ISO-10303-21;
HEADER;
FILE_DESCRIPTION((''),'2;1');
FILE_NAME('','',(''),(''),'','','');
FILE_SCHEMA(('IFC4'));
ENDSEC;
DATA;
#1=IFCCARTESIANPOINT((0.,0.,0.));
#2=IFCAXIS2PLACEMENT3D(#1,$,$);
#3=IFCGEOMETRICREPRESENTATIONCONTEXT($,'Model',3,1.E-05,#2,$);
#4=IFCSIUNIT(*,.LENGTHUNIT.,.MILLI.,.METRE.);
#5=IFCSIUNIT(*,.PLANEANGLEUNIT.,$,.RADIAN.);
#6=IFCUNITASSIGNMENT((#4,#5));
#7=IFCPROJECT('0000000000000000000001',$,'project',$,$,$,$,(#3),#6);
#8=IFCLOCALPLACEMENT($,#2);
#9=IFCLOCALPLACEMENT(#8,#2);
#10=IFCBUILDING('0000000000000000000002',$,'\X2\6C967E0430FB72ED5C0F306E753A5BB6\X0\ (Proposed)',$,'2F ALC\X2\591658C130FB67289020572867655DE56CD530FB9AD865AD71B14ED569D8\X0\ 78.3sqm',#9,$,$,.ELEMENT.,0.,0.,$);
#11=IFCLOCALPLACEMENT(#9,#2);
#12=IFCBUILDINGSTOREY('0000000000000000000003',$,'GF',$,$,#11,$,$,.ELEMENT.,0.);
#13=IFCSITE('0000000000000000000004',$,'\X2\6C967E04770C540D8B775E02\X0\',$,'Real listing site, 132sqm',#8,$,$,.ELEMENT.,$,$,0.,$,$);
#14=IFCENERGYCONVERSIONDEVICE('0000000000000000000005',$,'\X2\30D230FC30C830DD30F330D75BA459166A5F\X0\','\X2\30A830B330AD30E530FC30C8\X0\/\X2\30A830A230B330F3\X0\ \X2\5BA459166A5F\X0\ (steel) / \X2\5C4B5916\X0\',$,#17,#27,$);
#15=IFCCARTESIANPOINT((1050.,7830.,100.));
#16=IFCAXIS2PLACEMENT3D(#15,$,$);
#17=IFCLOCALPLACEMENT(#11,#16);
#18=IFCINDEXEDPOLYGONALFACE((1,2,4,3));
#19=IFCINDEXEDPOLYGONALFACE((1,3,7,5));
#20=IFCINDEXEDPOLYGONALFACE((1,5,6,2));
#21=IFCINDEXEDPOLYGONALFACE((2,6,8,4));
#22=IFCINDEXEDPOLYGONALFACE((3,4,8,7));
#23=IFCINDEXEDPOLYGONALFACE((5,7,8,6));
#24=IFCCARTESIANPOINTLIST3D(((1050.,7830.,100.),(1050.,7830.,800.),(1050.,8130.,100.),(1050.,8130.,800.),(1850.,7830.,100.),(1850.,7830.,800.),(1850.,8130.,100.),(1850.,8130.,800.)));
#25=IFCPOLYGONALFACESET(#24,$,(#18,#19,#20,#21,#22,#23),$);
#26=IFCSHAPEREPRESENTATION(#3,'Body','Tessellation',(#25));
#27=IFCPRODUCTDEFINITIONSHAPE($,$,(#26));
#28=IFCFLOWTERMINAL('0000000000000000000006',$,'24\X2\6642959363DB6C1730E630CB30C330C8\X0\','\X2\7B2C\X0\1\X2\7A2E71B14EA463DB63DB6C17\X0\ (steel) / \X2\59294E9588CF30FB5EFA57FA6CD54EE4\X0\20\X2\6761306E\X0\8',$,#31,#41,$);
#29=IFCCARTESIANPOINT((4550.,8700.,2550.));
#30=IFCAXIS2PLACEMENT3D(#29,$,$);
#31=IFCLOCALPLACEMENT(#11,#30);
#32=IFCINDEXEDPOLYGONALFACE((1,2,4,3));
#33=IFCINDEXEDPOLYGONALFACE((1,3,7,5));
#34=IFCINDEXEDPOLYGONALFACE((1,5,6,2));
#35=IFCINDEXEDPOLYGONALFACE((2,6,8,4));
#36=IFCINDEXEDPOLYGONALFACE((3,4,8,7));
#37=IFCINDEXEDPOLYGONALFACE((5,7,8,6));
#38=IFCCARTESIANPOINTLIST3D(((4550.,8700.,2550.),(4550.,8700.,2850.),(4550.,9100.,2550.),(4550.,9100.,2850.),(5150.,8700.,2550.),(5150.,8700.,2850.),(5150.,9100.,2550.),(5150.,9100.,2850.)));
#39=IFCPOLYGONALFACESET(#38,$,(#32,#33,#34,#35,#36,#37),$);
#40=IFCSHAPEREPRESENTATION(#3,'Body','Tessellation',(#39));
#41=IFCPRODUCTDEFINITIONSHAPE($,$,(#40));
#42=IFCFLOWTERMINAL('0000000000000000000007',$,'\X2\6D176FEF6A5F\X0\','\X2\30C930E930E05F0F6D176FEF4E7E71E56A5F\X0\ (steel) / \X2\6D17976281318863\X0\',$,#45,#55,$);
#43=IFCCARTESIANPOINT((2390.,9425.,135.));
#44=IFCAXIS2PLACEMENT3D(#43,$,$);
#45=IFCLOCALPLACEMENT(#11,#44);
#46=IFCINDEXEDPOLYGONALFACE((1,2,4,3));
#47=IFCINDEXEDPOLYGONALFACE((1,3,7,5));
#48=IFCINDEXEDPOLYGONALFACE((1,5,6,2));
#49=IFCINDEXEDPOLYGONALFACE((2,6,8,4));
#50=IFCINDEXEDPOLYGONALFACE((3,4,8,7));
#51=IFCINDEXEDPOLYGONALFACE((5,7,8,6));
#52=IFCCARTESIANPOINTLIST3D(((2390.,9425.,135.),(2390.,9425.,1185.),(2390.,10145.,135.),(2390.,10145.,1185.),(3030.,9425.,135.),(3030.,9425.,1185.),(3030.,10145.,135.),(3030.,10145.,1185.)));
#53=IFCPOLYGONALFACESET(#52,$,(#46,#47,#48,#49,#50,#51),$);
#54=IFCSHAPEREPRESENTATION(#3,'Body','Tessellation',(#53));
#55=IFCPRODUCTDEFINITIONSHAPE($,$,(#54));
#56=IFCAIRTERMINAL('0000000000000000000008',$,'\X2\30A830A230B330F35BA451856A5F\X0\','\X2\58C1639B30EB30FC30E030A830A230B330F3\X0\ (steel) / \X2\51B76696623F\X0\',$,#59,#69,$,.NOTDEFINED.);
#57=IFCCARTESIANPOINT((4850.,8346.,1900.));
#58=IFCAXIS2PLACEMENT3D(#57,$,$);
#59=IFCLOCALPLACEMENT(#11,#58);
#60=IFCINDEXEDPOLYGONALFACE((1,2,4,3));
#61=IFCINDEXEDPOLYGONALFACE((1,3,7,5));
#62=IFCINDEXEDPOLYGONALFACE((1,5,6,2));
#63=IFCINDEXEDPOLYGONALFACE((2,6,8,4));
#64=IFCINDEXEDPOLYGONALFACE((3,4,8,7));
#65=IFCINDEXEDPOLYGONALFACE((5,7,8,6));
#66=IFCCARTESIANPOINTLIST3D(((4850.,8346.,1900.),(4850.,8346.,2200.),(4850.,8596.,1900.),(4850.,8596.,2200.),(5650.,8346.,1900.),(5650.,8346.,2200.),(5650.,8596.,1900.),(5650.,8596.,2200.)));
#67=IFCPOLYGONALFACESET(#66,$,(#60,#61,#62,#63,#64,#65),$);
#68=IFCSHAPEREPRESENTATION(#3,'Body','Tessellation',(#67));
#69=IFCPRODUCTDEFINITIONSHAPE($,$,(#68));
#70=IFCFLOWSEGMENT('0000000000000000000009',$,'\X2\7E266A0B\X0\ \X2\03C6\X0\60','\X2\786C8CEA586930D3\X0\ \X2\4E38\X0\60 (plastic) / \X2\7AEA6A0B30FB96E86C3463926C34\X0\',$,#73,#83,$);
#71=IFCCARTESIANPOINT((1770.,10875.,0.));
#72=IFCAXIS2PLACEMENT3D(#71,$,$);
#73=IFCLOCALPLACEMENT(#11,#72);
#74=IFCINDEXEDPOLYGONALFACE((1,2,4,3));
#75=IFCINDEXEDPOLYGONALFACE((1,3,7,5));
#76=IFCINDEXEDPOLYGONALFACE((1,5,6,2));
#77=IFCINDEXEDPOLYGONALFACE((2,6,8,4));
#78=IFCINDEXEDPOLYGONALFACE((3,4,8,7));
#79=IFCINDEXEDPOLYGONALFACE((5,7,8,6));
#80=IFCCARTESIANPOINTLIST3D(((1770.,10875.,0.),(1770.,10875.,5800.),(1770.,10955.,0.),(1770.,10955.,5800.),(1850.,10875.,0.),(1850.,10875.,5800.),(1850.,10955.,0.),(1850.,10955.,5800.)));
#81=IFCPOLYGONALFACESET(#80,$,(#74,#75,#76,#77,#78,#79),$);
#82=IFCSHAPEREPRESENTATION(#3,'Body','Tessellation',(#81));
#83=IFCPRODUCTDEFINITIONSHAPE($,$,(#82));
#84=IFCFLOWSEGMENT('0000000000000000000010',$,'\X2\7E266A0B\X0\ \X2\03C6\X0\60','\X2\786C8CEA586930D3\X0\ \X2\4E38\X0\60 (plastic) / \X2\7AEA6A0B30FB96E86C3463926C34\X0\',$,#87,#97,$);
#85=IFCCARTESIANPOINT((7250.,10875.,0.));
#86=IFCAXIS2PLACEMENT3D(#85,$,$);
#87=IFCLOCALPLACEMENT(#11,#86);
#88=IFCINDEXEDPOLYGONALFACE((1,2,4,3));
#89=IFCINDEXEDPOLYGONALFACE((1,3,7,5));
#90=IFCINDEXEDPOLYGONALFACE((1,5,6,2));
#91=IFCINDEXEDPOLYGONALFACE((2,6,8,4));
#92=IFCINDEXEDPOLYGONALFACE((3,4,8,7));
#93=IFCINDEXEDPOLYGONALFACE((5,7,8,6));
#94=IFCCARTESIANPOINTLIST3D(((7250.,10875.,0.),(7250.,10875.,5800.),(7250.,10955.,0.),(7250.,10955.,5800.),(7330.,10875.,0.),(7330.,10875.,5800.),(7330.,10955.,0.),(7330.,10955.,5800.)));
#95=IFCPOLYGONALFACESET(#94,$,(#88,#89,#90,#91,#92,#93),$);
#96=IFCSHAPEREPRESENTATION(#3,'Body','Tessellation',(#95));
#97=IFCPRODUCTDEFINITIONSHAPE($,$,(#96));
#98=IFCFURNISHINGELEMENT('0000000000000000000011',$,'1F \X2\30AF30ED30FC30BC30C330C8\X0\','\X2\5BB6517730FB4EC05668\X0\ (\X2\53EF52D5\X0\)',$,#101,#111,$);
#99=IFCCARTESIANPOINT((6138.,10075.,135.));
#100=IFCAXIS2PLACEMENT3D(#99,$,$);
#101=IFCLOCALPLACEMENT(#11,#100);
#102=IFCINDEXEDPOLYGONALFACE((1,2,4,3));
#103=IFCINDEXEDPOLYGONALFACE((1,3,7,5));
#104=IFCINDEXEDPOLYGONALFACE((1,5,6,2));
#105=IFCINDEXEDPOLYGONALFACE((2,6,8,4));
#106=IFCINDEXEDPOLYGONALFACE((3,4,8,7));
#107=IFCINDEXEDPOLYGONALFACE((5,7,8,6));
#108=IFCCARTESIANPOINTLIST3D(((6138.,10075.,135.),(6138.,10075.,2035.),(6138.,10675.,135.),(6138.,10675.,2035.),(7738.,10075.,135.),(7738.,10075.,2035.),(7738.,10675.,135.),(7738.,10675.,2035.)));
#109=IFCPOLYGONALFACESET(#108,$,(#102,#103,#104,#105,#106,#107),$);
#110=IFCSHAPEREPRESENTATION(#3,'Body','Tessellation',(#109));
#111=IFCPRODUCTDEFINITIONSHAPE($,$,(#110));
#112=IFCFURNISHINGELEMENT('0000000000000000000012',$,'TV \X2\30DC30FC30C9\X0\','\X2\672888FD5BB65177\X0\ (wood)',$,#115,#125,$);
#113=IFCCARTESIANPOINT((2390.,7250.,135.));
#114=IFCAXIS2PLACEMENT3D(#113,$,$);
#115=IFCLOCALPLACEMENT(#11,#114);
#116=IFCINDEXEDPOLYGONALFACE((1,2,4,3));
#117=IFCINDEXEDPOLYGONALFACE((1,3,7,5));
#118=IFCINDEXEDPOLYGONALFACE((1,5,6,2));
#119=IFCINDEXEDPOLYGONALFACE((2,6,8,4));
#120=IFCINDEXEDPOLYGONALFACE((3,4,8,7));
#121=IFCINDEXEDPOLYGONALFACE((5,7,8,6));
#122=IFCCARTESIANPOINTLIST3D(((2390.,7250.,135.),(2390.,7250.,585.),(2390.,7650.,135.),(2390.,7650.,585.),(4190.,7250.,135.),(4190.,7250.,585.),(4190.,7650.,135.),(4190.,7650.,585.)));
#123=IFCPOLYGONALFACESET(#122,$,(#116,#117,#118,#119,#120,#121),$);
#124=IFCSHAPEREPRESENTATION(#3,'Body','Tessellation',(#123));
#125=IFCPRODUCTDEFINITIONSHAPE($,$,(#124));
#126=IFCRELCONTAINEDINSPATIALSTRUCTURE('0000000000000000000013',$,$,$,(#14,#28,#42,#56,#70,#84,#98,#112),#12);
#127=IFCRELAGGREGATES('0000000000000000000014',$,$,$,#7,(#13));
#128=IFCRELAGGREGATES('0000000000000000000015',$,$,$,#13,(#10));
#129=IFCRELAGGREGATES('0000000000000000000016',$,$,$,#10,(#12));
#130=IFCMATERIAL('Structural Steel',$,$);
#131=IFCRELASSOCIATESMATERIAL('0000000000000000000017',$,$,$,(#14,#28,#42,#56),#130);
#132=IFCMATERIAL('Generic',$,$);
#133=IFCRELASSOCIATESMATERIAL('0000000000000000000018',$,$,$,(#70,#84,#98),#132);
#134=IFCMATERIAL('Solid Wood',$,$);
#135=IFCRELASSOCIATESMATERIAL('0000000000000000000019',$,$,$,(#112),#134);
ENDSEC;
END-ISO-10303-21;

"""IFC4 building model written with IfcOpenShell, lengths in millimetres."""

from ifc_helpers import new_model, si_unit, frame, frame_2d, origin, place, context, project, spatial, rectangle, extrude, material, element, save


model = new_model("IFC4")

# Units and contexts
model_context = context("Model", 3, precision=1e-05, world=origin())
ifc_project = project(units=[si_unit("LENGTHUNIT", "METRE", prefix="MILLI"), si_unit("PLANEANGLEUNIT", "RADIAN")], contexts=[model_context])

# Site, building, storey
site_placement = place(None, origin())
site = spatial("IfcSite", under=ifc_project, at=site_placement, Name="沖縄県名護市", ObjectType="Real listing site, 132sqm", CompositionType="ELEMENT", RefElevation=0.0)
building_placement = place(site_placement, origin())
building = spatial("IfcBuilding", under=site, at=building_placement, Name="沖縄・狭小の町家 (Proposed)", ObjectType="2F ALC外壁・木造在来工法・高断熱仕様 78.3sqm", CompositionType="ELEMENT", ElevationOfRefHeight=0.0, ElevationOfTerrain=0.0)
storey_placement = place(building_placement, origin())
storey = spatial("IfcBuildingStorey", under=building, at=storey_placement, Name="GF", CompositionType="ELEMENT", Elevation=0.0)

# Shared definitions
ifc_material_1 = material(Name="Solid Wood")

# Shared definitions
ifc_material_2 = material(Name="Generic")

# Shared definitions
ifc_material_3 = material(Name="Structural Steel")

# Energy conversion device
energy_conversion_device_placement = place(storey_placement, frame((1050.0, 7830.0, 100.0)))
element("IfcEnergyConversionDevice", 1, at=energy_conversion_device_placement, inside=storey, material=ifc_material_3, Name="ヒートポンプ室外機", Description="エコキュート/エアコン 室外機 (steel) / 屋外", context=model_context, shape_type="SweptSolid", body=[
    extrude(rectangle(XDim=800.0, YDim=300.0, at=frame_2d((400.0, 150.0))), frame((1050.0, 7830.0, 100.0)), (0.0, 0.0, 1.0), 700.0),
])

# Flow terminals
flow_terminal_1_placement = place(storey_placement, frame((4550.0, 8700.0, 2550.0)))
element("IfcFlowTerminal", 2, at=flow_terminal_1_placement, inside=storey, material=ifc_material_3, Name="24時間換気ユニット", Description="第1種熱交換換気 (steel) / 天井裏・建基法令20条の8", context=model_context, shape_type="SweptSolid", body=[
    extrude(rectangle(XDim=600.0, YDim=400.0, at=frame_2d((300.0, 200.0))), frame((4550.0, 8700.0, 2550.0)), (0.0, 0.0, 1.0), 300.0),
])
flow_terminal_2_placement = place(storey_placement, frame((2390.0, 9425.0, 135.0)))
element("IfcFlowTerminal", 3, at=flow_terminal_2_placement, inside=storey, material=ifc_material_3, Name="洗濯機", Description="ドラム式洗濯乾燥機 (steel) / 洗面脱衣", context=model_context, shape_type="SweptSolid", body=[
    extrude(rectangle(XDim=640.0, YDim=720.0, at=frame_2d((320.0, 360.0))), frame((2390.0, 9425.0, 135.0)), (0.0, 0.0, 1.0), 1050.0),
])

# Air terminal
air_terminal_placement = place(storey_placement, frame((4850.0, 8346.0, 1900.0)))
element("IfcAirTerminal", 4, at=air_terminal_placement, inside=storey, material=ifc_material_3, Name="エアコン室内機", Description="壁掛ルームエアコン (steel) / 冷暖房", PredefinedType="NOTDEFINED", context=model_context, shape_type="SweptSolid", body=[
    extrude(rectangle(XDim=800.0, YDim=250.0, at=frame_2d((400.0, 125.0))), frame((4850.0, 8346.0, 1900.0)), (0.0, 0.0, 1.0), 300.0),
])

# Flow segments
flow_segment_1_placement = place(storey_placement, frame((1770.0, 10875.0, 0.0)))
element("IfcFlowSegment", 5, at=flow_segment_1_placement, inside=storey, material=ifc_material_2, Name="縦樋 φ60", Description="硬質塩ビ 丸60 (plastic) / 竪樋・雨水排水", context=model_context, shape_type="SweptSolid", body=[
    extrude(rectangle(XDim=80.0, YDim=80.0, at=frame_2d((40.0, 40.0))), frame((1770.0, 10875.0, 0.0)), (0.0, 0.0, 1.0), 5800.0),
])
flow_segment_2_placement = place(storey_placement, frame((7250.0, 10875.0, 0.0)))
element("IfcFlowSegment", 6, at=flow_segment_2_placement, inside=storey, material=ifc_material_2, Name="縦樋 φ60", Description="硬質塩ビ 丸60 (plastic) / 竪樋・雨水排水", context=model_context, shape_type="SweptSolid", body=[
    extrude(rectangle(XDim=80.0, YDim=80.0, at=frame_2d((40.0, 40.0))), frame((7250.0, 10875.0, 0.0)), (0.0, 0.0, 1.0), 5800.0),
])

# Furnishing elements
furnishing_1_placement = place(storey_placement, frame((6138.0, 10075.0, 135.0)))
element("IfcFurnishingElement", 7, at=furnishing_1_placement, inside=storey, material=ifc_material_2, Name="1F クローゼット", Description="家具・什器 (可動)", context=model_context, shape_type="SweptSolid", body=[
    extrude(rectangle(XDim=1600.0, YDim=600.0, at=frame_2d((800.0, 300.0))), frame((6138.0, 10075.0, 135.0)), (0.0, 0.0, 1.0), 1900.0),
])
furnishing_2_placement = place(storey_placement, frame((2390.0, 7250.0, 135.0)))
element("IfcFurnishingElement", 8, at=furnishing_2_placement, inside=storey, material=ifc_material_1, Name="TV ボード", Description="木製家具 (wood)", context=model_context, shape_type="SweptSolid", body=[
    extrude(rectangle(XDim=1800.0, YDim=400.0, at=frame_2d((900.0, 200.0))), frame((2390.0, 7250.0, 135.0)), (0.0, 0.0, 1.0), 450.0),
])

save(model, "model.ifc")
